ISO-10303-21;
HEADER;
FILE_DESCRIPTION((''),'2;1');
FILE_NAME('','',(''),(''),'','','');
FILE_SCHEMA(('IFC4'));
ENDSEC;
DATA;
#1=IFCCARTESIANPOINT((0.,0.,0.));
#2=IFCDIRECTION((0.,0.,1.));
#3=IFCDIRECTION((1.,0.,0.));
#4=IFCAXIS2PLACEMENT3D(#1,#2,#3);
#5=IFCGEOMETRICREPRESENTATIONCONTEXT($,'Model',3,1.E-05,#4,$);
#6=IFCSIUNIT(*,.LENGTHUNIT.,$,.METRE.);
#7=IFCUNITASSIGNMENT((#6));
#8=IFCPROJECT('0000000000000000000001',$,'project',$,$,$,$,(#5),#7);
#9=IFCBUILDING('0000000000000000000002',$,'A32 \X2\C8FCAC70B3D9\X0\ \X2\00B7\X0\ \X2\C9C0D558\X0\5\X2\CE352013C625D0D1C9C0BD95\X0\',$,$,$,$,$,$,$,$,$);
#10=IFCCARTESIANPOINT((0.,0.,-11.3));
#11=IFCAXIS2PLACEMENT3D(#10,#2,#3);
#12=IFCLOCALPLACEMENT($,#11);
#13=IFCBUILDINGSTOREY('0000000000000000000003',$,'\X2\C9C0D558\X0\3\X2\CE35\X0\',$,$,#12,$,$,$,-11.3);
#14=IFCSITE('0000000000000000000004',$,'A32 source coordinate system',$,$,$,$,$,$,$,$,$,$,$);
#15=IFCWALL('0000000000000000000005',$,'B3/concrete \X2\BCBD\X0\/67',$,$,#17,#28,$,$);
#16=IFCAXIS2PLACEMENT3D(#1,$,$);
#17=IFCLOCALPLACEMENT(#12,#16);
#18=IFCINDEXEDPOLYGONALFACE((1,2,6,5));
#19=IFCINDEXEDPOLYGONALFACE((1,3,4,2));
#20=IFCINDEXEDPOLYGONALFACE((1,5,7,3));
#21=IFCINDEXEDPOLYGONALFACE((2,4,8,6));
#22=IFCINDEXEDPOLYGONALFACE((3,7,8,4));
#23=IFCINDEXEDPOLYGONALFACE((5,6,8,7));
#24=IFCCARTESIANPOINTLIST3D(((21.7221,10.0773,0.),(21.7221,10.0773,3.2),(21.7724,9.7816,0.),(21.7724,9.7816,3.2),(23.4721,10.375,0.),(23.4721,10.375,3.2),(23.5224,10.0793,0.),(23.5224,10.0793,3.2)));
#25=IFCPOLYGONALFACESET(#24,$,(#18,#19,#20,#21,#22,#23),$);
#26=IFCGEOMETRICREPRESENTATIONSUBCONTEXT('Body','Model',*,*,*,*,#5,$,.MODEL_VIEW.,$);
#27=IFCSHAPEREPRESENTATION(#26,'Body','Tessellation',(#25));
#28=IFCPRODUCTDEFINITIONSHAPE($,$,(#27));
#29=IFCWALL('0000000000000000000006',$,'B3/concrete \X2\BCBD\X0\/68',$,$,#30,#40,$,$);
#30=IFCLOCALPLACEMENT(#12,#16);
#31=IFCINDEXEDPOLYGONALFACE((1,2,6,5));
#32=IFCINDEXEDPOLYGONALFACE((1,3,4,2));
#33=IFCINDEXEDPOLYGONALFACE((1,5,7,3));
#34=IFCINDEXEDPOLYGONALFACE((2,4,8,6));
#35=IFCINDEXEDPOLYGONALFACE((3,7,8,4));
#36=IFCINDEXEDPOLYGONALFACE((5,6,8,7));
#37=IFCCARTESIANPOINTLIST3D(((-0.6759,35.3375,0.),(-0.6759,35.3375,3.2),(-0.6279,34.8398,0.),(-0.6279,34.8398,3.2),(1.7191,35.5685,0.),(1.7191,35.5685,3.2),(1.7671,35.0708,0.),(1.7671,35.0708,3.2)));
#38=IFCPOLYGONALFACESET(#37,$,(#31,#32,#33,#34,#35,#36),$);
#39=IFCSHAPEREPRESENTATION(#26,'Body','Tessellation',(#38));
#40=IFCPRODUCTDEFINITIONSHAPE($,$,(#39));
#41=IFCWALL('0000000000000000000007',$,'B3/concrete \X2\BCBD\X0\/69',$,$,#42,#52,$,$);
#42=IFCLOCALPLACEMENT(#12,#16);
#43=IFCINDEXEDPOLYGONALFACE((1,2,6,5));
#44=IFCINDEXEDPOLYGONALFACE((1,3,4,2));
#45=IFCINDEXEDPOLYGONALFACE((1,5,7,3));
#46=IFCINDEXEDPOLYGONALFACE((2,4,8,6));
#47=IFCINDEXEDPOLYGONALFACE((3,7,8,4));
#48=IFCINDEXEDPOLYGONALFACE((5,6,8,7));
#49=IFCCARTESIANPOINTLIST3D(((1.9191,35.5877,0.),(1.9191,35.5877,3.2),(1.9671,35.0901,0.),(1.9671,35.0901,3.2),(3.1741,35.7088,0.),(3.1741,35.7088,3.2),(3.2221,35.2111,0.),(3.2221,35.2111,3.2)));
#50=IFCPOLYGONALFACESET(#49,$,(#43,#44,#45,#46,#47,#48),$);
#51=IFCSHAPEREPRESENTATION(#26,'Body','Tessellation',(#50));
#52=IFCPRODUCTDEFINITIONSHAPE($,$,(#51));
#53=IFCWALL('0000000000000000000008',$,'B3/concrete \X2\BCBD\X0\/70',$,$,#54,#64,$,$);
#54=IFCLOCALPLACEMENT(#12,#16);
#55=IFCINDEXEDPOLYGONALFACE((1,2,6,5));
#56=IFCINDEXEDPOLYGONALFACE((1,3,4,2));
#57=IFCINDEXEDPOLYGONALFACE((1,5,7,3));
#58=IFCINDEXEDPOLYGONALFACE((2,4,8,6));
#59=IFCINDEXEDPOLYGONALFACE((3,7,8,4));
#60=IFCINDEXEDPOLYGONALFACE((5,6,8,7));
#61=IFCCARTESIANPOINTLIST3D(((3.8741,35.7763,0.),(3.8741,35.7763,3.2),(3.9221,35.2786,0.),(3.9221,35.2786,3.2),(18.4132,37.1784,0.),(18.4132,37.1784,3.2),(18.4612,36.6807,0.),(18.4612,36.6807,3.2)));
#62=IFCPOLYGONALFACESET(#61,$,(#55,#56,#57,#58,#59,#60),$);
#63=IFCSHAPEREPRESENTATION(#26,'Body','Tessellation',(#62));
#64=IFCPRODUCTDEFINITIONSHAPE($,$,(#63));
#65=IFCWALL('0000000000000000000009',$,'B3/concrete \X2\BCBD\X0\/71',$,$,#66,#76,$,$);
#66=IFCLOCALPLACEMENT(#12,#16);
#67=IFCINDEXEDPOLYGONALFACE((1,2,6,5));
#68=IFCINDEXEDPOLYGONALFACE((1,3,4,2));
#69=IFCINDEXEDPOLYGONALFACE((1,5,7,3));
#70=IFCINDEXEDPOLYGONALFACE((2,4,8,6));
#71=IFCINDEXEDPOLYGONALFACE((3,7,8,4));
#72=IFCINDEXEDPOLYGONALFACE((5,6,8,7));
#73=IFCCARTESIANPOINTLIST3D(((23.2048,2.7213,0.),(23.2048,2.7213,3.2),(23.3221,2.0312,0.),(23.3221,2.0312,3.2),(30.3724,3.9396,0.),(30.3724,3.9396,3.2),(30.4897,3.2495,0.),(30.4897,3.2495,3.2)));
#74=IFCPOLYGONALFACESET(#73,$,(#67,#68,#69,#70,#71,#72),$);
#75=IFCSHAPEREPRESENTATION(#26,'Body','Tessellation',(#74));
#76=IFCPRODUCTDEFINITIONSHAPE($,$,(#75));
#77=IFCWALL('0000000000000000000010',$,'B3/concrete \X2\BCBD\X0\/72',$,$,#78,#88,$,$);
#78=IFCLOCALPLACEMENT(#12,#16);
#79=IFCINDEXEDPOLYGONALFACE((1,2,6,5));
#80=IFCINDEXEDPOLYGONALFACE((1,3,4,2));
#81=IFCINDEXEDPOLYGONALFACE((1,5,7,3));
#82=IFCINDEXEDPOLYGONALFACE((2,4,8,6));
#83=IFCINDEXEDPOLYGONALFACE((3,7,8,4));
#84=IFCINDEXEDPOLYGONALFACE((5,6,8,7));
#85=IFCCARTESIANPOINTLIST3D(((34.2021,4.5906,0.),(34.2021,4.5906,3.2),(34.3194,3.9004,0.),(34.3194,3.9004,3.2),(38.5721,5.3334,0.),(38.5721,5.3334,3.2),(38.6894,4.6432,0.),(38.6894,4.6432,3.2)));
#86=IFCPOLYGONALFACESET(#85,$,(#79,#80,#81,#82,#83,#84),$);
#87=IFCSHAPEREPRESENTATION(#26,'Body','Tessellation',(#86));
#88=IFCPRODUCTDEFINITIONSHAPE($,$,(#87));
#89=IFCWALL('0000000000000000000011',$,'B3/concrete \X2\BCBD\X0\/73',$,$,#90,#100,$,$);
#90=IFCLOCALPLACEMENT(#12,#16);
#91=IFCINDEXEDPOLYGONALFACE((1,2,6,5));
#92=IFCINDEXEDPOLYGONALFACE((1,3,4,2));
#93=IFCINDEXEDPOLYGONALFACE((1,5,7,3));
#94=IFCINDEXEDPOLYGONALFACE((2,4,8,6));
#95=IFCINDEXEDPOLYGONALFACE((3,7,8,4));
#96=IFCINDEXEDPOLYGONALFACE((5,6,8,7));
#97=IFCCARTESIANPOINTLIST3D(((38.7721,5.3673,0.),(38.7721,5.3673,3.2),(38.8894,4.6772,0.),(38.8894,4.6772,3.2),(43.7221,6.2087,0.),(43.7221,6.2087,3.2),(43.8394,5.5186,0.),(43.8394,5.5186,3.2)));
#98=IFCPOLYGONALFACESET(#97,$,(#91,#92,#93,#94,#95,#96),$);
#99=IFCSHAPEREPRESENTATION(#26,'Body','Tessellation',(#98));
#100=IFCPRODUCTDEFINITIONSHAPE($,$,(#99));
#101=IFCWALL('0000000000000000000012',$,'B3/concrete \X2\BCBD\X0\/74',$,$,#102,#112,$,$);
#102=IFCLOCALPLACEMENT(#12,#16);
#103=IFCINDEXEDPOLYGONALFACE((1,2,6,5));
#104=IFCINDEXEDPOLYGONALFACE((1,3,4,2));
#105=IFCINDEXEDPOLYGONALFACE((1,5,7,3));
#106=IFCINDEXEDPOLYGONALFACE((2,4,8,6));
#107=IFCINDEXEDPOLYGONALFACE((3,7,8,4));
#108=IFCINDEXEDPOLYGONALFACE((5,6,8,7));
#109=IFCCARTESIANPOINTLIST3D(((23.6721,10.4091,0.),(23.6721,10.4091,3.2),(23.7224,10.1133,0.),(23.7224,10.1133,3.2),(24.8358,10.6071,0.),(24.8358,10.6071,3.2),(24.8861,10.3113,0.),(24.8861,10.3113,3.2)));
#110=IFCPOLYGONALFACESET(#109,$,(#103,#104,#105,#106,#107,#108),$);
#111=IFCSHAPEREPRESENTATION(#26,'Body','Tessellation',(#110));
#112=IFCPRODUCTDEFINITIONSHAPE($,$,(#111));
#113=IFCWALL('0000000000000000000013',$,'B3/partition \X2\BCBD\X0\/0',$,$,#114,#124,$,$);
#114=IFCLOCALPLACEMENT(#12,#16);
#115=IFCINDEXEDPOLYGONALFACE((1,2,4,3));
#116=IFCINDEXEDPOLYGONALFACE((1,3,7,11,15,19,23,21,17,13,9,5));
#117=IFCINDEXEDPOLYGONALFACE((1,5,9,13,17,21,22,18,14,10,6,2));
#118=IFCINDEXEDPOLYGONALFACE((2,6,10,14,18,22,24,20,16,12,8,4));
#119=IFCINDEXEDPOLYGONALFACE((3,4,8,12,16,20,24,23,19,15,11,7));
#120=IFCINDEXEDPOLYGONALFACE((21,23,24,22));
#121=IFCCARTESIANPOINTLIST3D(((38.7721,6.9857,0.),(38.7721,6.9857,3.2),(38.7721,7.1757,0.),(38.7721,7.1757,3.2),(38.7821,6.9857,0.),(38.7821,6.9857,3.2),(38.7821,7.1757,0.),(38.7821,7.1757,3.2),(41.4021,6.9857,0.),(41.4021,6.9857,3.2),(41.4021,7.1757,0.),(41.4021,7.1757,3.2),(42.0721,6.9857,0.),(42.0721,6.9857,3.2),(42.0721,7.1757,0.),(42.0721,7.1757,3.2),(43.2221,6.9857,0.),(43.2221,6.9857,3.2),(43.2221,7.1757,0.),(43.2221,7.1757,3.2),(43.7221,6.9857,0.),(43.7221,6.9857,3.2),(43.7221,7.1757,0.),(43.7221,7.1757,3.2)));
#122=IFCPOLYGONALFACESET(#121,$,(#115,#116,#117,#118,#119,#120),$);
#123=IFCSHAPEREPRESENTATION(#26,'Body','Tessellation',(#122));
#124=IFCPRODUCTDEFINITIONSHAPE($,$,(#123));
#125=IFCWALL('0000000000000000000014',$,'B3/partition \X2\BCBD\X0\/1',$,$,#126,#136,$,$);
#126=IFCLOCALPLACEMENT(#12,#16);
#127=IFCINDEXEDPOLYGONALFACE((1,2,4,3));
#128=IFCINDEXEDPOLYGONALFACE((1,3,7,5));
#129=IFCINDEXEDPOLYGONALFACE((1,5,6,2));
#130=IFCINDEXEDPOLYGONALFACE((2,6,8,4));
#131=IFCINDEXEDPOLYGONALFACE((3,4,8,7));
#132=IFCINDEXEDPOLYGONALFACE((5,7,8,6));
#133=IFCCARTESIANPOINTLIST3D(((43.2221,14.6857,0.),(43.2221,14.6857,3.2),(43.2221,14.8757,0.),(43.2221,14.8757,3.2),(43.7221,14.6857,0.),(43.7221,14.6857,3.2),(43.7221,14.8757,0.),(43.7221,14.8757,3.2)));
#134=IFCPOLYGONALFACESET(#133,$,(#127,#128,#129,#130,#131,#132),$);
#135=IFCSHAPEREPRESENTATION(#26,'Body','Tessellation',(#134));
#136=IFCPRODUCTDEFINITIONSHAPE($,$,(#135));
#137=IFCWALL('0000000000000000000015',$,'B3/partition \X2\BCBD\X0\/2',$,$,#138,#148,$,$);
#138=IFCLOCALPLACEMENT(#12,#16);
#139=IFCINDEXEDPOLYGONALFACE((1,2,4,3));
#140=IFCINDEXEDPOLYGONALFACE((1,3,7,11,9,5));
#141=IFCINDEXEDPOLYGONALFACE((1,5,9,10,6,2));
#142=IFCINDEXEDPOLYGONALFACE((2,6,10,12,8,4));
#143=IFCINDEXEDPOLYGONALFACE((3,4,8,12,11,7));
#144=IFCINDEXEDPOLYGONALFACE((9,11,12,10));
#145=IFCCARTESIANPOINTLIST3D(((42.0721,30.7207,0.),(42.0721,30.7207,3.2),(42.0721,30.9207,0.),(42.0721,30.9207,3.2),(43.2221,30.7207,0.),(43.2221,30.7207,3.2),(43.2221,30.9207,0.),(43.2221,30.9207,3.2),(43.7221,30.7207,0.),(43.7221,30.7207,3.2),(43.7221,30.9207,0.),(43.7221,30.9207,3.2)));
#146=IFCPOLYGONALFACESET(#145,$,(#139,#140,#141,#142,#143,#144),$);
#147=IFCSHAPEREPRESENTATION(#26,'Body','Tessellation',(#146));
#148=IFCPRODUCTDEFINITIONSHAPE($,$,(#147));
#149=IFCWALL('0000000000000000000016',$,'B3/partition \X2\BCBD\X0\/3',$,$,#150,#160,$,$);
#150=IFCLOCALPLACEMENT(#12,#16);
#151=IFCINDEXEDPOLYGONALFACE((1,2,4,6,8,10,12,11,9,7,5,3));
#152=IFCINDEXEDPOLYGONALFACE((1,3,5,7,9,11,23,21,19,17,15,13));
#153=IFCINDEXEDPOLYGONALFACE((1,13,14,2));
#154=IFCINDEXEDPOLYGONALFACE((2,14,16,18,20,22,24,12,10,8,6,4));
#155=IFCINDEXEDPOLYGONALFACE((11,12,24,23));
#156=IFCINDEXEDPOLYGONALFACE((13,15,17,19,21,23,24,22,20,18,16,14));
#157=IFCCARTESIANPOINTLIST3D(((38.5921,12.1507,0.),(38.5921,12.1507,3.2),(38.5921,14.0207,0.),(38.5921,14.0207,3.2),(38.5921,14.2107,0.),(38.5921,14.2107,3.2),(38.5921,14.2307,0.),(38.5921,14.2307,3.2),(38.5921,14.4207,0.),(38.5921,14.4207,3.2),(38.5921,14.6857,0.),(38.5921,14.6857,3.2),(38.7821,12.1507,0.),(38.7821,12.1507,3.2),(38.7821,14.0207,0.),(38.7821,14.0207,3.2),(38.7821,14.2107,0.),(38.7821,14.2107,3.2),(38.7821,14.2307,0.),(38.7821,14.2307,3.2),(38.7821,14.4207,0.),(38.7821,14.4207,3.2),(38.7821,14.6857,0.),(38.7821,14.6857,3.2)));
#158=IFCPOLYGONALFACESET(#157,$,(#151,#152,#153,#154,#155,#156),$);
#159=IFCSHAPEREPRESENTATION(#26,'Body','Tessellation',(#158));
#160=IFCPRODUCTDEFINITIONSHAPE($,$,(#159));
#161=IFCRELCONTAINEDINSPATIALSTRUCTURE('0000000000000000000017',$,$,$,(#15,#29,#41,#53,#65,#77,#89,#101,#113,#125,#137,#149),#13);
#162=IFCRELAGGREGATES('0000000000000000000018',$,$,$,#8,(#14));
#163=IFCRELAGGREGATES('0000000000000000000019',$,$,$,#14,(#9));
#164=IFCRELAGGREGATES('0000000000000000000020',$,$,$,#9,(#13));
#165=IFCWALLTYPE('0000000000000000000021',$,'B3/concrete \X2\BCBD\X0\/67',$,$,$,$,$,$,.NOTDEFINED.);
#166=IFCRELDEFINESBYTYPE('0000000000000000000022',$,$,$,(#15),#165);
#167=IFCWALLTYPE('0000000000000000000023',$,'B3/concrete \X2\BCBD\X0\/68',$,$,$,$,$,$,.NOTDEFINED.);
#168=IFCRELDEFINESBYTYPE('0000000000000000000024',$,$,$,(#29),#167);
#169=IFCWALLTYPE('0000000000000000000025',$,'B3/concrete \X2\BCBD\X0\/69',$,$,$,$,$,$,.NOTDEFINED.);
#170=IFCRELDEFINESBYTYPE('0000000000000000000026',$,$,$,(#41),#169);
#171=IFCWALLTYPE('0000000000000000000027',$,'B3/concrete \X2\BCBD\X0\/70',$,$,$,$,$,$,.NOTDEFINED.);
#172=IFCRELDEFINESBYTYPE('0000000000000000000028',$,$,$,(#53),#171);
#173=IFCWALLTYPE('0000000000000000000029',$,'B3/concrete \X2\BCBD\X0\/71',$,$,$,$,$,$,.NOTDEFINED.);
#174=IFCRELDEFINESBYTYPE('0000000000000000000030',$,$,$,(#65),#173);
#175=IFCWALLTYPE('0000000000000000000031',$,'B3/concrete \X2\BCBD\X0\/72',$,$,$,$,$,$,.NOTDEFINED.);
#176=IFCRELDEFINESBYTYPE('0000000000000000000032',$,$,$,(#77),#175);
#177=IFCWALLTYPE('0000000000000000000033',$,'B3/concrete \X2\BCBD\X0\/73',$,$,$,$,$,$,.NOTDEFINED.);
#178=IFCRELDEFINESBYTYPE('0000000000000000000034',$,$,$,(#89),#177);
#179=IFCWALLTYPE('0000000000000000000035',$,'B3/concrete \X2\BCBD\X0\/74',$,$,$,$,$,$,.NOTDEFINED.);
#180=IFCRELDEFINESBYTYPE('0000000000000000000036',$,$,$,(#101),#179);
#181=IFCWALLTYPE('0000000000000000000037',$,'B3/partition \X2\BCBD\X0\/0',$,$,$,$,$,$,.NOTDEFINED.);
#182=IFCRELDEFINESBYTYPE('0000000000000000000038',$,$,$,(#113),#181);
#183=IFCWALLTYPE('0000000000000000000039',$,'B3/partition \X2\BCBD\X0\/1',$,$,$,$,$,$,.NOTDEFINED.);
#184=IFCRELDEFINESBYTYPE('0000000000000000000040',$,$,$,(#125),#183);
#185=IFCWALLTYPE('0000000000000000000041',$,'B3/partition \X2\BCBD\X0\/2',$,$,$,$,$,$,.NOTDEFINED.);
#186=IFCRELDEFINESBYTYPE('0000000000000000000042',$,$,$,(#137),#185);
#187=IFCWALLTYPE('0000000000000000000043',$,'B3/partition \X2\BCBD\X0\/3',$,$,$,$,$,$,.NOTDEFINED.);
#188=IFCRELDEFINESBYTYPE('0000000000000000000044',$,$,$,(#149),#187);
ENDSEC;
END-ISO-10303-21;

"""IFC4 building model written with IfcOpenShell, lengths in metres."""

from ifc_helpers import new_model, si_unit, frame, origin, origin_with_axes, place, context, subcontext, project, spatial, polyline, outline, extrude, source, transform, mapped, type_object, type_shapes, element, save


model = new_model("IFC4")

# Units and contexts
model_context = context("Model", 3, precision=1e-05, world=origin_with_axes())
body_context = subcontext(model_context, "Body", "Model", "MODEL_VIEW")
ifc_project = project(units=[si_unit("LENGTHUNIT", "METRE")], contexts=[model_context])

# Site, building, storey
site = spatial("IfcSite", under=ifc_project, Name="A32 source coordinate system")
building = spatial("IfcBuilding", under=site, Name="A32 주거동 · 지하5층–옥탑지붕")
storey_placement = place(None, frame((0.0, 0.0, -11.3), z_axis=(0.0, 0.0, 1.0), x_axis=(1.0, 0.0, 0.0)))
storey = spatial("IfcBuildingStorey", under=building, at=storey_placement, Name="지하3층", Elevation=-11.3)

# Walls
wall_type_1 = type_object("IfcWallType", Name="B3/concrete 벽/67", PredefinedType="NOTDEFINED")
shared_shape_1 = source(origin(), body_context, "Body", "SweptSolid", [
    extrude(outline(polyline([(21.7221, 10.0773), (23.4721, 10.375), (23.5224, 10.0793), (21.7724, 9.7816), (21.7221, 10.0773)])), origin(), (0.0, 0.0, 1.0), 3.2),
])
type_shapes(wall_type_1, [shared_shape_1])
wall_1_placement = place(storey_placement, origin_with_axes())
element("IfcWall", 1, at=wall_1_placement, inside=storey, type_object=wall_type_1, Name="B3/concrete 벽/67", context=body_context, shape_type="MappedRepresentation", body=[
    mapped(shared_shape_1, transform((0.0, 0.0, 0.0), scale=1.0)),
])
wall_type_2 = type_object("IfcWallType", Name="B3/concrete 벽/68", PredefinedType="NOTDEFINED")
shared_shape_2 = source(origin(), body_context, "Body", "SweptSolid", [
    extrude(outline(polyline([(-0.6279, 34.8398), (-0.6759, 35.3375), (1.7191, 35.5685), (1.7671, 35.0708), (-0.6279, 34.8398)])), origin(), (0.0, 0.0, 1.0), 3.2),
])
type_shapes(wall_type_2, [shared_shape_2])
wall_2_placement = place(storey_placement, origin_with_axes())
element("IfcWall", 2, at=wall_2_placement, inside=storey, type_object=wall_type_2, Name="B3/concrete 벽/68", context=body_context, shape_type="MappedRepresentation", body=[
    mapped(shared_shape_2, transform((0.0, 0.0, 0.0), scale=1.0)),
])
wall_type_3 = type_object("IfcWallType", Name="B3/concrete 벽/69", PredefinedType="NOTDEFINED")
shared_shape_3 = source(origin(), body_context, "Body", "SweptSolid", [
    extrude(outline(polyline([(1.9671, 35.0901), (1.9191, 35.5877), (3.1741, 35.7088), (3.2221, 35.2111), (1.9671, 35.0901)])), origin(), (0.0, 0.0, 1.0), 3.2),
])
type_shapes(wall_type_3, [shared_shape_3])
wall_3_placement = place(storey_placement, origin_with_axes())
element("IfcWall", 3, at=wall_3_placement, inside=storey, type_object=wall_type_3, Name="B3/concrete 벽/69", context=body_context, shape_type="MappedRepresentation", body=[
    mapped(shared_shape_3, transform((0.0, 0.0, 0.0), scale=1.0)),
])
wall_type_4 = type_object("IfcWallType", Name="B3/concrete 벽/70", PredefinedType="NOTDEFINED")
shared_shape_4 = source(origin(), body_context, "Body", "SweptSolid", [
    extrude(outline(polyline([(18.4612, 36.6807), (3.9221, 35.2786), (3.8741, 35.7763), (18.4132, 37.1784), (18.4612, 36.6807)])), origin(), (0.0, 0.0, 1.0), 3.2),
])
type_shapes(wall_type_4, [shared_shape_4])
wall_4_placement = place(storey_placement, origin_with_axes())
element("IfcWall", 4, at=wall_4_placement, inside=storey, type_object=wall_type_4, Name="B3/concrete 벽/70", context=body_context, shape_type="MappedRepresentation", body=[
    mapped(shared_shape_4, transform((0.0, 0.0, 0.0), scale=1.0)),
])
wall_type_5 = type_object("IfcWallType", Name="B3/concrete 벽/71", PredefinedType="NOTDEFINED")
shared_shape_5 = source(origin(), body_context, "Body", "SweptSolid", [
    extrude(outline(polyline([(30.4897, 3.2495), (23.3221, 2.0312), (23.2048, 2.7213), (30.3724, 3.9396), (30.4897, 3.2495)])), origin(), (0.0, 0.0, 1.0), 3.2),
])
type_shapes(wall_type_5, [shared_shape_5])
wall_5_placement = place(storey_placement, origin_with_axes())
element("IfcWall", 5, at=wall_5_placement, inside=storey, type_object=wall_type_5, Name="B3/concrete 벽/71", context=body_context, shape_type="MappedRepresentation", body=[
    mapped(shared_shape_5, transform((0.0, 0.0, 0.0), scale=1.0)),
])
wall_type_6 = type_object("IfcWallType", Name="B3/concrete 벽/72", PredefinedType="NOTDEFINED")
shared_shape_6 = source(origin(), body_context, "Body", "SweptSolid", [
    extrude(outline(polyline([(38.5721, 5.3334), (38.6894, 4.6432), (34.3194, 3.9004), (34.2021, 4.5906), (38.5721, 5.3334)])), origin(), (0.0, 0.0, 1.0), 3.2),
])
type_shapes(wall_type_6, [shared_shape_6])
wall_6_placement = place(storey_placement, origin_with_axes())
element("IfcWall", 6, at=wall_6_placement, inside=storey, type_object=wall_type_6, Name="B3/concrete 벽/72", context=body_context, shape_type="MappedRepresentation", body=[
    mapped(shared_shape_6, transform((0.0, 0.0, 0.0), scale=1.0)),
])
wall_type_7 = type_object("IfcWallType", Name="B3/concrete 벽/73", PredefinedType="NOTDEFINED")
shared_shape_7 = source(origin(), body_context, "Body", "SweptSolid", [
    extrude(outline(polyline([(38.7721, 5.3673), (43.7221, 6.2087), (43.8394, 5.5186), (38.8894, 4.6772), (38.7721, 5.3673)])), origin(), (0.0, 0.0, 1.0), 3.2),
])
type_shapes(wall_type_7, [shared_shape_7])
wall_7_placement = place(storey_placement, origin_with_axes())
element("IfcWall", 7, at=wall_7_placement, inside=storey, type_object=wall_type_7, Name="B3/concrete 벽/73", context=body_context, shape_type="MappedRepresentation", body=[
    mapped(shared_shape_7, transform((0.0, 0.0, 0.0), scale=1.0)),
])
wall_type_8 = type_object("IfcWallType", Name="B3/concrete 벽/74", PredefinedType="NOTDEFINED")
shared_shape_8 = source(origin(), body_context, "Body", "SweptSolid", [
    extrude(outline(polyline([(24.8358, 10.6071), (24.8861, 10.3113), (23.7224, 10.1133), (23.6721, 10.4091), (24.8358, 10.6071)])), origin(), (0.0, 0.0, 1.0), 3.2),
])
type_shapes(wall_type_8, [shared_shape_8])
wall_8_placement = place(storey_placement, origin_with_axes())
element("IfcWall", 8, at=wall_8_placement, inside=storey, type_object=wall_type_8, Name="B3/concrete 벽/74", context=body_context, shape_type="MappedRepresentation", body=[
    mapped(shared_shape_8, transform((0.0, 0.0, 0.0), scale=1.0)),
])
wall_type_9 = type_object("IfcWallType", Name="B3/partition 벽/0", PredefinedType="NOTDEFINED")
shared_shape_9 = source(origin(), body_context, "Body", "SweptSolid", [
    extrude(outline(polyline([(38.7721, 7.1757), (38.7821, 7.1757), (41.4021, 7.1757), (42.0721, 7.1757), (43.2221, 7.1757), (43.7221, 7.1757), (43.7221, 6.9857), (43.2221, 6.9857), (42.0721, 6.9857), (41.4021, 6.9857), (38.7821, 6.9857), (38.7721, 6.9857), (38.7721, 7.1757)])), origin(), (0.0, 0.0, 1.0), 3.2),
])
type_shapes(wall_type_9, [shared_shape_9])
wall_9_placement = place(storey_placement, origin_with_axes())
element("IfcWall", 9, at=wall_9_placement, inside=storey, type_object=wall_type_9, Name="B3/partition 벽/0", context=body_context, shape_type="MappedRepresentation", body=[
    mapped(shared_shape_9, transform((0.0, 0.0, 0.0), scale=1.0)),
])
wall_type_10 = type_object("IfcWallType", Name="B3/partition 벽/1", PredefinedType="NOTDEFINED")
shared_shape_10 = source(origin(), body_context, "Body", "SweptSolid", [
    extrude(outline(polyline([(43.7221, 14.8757), (43.7221, 14.6857), (43.2221, 14.6857), (43.2221, 14.8757), (43.7221, 14.8757)])), origin(), (0.0, 0.0, 1.0), 3.2),
])
type_shapes(wall_type_10, [shared_shape_10])
wall_10_placement = place(storey_placement, origin_with_axes())
element("IfcWall", 10, at=wall_10_placement, inside=storey, type_object=wall_type_10, Name="B3/partition 벽/1", context=body_context, shape_type="MappedRepresentation", body=[
    mapped(shared_shape_10, transform((0.0, 0.0, 0.0), scale=1.0)),
])
wall_type_11 = type_object("IfcWallType", Name="B3/partition 벽/2", PredefinedType="NOTDEFINED")
shared_shape_11 = source(origin(), body_context, "Body", "SweptSolid", [
    extrude(outline(polyline([(42.0721, 30.7207), (42.0721, 30.9207), (43.2221, 30.9207), (43.7221, 30.9207), (43.7221, 30.7207), (43.2221, 30.7207), (42.0721, 30.7207)])), origin(), (0.0, 0.0, 1.0), 3.2),
])
type_shapes(wall_type_11, [shared_shape_11])
wall_11_placement = place(storey_placement, origin_with_axes())
element("IfcWall", 11, at=wall_11_placement, inside=storey, type_object=wall_type_11, Name="B3/partition 벽/2", context=body_context, shape_type="MappedRepresentation", body=[
    mapped(shared_shape_11, transform((0.0, 0.0, 0.0), scale=1.0)),
])
wall_type_12 = type_object("IfcWallType", Name="B3/partition 벽/3", PredefinedType="NOTDEFINED")
shared_shape_12 = source(origin(), body_context, "Body", "SweptSolid", [
    extrude(outline(polyline([(38.5921, 14.4207), (38.5921, 14.6857), (38.7821, 14.6857), (38.7821, 14.4207), (38.7821, 14.2307), (38.7821, 14.2107), (38.7821, 14.0207), (38.7821, 12.1507), (38.5921, 12.1507), (38.5921, 14.0207), (38.5921, 14.2107), (38.5921, 14.2307), (38.5921, 14.4207)])), origin(), (0.0, 0.0, 1.0), 3.2),
])
type_shapes(wall_type_12, [shared_shape_12])
wall_12_placement = place(storey_placement, origin_with_axes())
element("IfcWall", 12, at=wall_12_placement, inside=storey, type_object=wall_type_12, Name="B3/partition 벽/3", context=body_context, shape_type="MappedRepresentation", body=[
    mapped(shared_shape_12, transform((0.0, 0.0, 0.0), scale=1.0)),
])

save(model, "model.ifc")
